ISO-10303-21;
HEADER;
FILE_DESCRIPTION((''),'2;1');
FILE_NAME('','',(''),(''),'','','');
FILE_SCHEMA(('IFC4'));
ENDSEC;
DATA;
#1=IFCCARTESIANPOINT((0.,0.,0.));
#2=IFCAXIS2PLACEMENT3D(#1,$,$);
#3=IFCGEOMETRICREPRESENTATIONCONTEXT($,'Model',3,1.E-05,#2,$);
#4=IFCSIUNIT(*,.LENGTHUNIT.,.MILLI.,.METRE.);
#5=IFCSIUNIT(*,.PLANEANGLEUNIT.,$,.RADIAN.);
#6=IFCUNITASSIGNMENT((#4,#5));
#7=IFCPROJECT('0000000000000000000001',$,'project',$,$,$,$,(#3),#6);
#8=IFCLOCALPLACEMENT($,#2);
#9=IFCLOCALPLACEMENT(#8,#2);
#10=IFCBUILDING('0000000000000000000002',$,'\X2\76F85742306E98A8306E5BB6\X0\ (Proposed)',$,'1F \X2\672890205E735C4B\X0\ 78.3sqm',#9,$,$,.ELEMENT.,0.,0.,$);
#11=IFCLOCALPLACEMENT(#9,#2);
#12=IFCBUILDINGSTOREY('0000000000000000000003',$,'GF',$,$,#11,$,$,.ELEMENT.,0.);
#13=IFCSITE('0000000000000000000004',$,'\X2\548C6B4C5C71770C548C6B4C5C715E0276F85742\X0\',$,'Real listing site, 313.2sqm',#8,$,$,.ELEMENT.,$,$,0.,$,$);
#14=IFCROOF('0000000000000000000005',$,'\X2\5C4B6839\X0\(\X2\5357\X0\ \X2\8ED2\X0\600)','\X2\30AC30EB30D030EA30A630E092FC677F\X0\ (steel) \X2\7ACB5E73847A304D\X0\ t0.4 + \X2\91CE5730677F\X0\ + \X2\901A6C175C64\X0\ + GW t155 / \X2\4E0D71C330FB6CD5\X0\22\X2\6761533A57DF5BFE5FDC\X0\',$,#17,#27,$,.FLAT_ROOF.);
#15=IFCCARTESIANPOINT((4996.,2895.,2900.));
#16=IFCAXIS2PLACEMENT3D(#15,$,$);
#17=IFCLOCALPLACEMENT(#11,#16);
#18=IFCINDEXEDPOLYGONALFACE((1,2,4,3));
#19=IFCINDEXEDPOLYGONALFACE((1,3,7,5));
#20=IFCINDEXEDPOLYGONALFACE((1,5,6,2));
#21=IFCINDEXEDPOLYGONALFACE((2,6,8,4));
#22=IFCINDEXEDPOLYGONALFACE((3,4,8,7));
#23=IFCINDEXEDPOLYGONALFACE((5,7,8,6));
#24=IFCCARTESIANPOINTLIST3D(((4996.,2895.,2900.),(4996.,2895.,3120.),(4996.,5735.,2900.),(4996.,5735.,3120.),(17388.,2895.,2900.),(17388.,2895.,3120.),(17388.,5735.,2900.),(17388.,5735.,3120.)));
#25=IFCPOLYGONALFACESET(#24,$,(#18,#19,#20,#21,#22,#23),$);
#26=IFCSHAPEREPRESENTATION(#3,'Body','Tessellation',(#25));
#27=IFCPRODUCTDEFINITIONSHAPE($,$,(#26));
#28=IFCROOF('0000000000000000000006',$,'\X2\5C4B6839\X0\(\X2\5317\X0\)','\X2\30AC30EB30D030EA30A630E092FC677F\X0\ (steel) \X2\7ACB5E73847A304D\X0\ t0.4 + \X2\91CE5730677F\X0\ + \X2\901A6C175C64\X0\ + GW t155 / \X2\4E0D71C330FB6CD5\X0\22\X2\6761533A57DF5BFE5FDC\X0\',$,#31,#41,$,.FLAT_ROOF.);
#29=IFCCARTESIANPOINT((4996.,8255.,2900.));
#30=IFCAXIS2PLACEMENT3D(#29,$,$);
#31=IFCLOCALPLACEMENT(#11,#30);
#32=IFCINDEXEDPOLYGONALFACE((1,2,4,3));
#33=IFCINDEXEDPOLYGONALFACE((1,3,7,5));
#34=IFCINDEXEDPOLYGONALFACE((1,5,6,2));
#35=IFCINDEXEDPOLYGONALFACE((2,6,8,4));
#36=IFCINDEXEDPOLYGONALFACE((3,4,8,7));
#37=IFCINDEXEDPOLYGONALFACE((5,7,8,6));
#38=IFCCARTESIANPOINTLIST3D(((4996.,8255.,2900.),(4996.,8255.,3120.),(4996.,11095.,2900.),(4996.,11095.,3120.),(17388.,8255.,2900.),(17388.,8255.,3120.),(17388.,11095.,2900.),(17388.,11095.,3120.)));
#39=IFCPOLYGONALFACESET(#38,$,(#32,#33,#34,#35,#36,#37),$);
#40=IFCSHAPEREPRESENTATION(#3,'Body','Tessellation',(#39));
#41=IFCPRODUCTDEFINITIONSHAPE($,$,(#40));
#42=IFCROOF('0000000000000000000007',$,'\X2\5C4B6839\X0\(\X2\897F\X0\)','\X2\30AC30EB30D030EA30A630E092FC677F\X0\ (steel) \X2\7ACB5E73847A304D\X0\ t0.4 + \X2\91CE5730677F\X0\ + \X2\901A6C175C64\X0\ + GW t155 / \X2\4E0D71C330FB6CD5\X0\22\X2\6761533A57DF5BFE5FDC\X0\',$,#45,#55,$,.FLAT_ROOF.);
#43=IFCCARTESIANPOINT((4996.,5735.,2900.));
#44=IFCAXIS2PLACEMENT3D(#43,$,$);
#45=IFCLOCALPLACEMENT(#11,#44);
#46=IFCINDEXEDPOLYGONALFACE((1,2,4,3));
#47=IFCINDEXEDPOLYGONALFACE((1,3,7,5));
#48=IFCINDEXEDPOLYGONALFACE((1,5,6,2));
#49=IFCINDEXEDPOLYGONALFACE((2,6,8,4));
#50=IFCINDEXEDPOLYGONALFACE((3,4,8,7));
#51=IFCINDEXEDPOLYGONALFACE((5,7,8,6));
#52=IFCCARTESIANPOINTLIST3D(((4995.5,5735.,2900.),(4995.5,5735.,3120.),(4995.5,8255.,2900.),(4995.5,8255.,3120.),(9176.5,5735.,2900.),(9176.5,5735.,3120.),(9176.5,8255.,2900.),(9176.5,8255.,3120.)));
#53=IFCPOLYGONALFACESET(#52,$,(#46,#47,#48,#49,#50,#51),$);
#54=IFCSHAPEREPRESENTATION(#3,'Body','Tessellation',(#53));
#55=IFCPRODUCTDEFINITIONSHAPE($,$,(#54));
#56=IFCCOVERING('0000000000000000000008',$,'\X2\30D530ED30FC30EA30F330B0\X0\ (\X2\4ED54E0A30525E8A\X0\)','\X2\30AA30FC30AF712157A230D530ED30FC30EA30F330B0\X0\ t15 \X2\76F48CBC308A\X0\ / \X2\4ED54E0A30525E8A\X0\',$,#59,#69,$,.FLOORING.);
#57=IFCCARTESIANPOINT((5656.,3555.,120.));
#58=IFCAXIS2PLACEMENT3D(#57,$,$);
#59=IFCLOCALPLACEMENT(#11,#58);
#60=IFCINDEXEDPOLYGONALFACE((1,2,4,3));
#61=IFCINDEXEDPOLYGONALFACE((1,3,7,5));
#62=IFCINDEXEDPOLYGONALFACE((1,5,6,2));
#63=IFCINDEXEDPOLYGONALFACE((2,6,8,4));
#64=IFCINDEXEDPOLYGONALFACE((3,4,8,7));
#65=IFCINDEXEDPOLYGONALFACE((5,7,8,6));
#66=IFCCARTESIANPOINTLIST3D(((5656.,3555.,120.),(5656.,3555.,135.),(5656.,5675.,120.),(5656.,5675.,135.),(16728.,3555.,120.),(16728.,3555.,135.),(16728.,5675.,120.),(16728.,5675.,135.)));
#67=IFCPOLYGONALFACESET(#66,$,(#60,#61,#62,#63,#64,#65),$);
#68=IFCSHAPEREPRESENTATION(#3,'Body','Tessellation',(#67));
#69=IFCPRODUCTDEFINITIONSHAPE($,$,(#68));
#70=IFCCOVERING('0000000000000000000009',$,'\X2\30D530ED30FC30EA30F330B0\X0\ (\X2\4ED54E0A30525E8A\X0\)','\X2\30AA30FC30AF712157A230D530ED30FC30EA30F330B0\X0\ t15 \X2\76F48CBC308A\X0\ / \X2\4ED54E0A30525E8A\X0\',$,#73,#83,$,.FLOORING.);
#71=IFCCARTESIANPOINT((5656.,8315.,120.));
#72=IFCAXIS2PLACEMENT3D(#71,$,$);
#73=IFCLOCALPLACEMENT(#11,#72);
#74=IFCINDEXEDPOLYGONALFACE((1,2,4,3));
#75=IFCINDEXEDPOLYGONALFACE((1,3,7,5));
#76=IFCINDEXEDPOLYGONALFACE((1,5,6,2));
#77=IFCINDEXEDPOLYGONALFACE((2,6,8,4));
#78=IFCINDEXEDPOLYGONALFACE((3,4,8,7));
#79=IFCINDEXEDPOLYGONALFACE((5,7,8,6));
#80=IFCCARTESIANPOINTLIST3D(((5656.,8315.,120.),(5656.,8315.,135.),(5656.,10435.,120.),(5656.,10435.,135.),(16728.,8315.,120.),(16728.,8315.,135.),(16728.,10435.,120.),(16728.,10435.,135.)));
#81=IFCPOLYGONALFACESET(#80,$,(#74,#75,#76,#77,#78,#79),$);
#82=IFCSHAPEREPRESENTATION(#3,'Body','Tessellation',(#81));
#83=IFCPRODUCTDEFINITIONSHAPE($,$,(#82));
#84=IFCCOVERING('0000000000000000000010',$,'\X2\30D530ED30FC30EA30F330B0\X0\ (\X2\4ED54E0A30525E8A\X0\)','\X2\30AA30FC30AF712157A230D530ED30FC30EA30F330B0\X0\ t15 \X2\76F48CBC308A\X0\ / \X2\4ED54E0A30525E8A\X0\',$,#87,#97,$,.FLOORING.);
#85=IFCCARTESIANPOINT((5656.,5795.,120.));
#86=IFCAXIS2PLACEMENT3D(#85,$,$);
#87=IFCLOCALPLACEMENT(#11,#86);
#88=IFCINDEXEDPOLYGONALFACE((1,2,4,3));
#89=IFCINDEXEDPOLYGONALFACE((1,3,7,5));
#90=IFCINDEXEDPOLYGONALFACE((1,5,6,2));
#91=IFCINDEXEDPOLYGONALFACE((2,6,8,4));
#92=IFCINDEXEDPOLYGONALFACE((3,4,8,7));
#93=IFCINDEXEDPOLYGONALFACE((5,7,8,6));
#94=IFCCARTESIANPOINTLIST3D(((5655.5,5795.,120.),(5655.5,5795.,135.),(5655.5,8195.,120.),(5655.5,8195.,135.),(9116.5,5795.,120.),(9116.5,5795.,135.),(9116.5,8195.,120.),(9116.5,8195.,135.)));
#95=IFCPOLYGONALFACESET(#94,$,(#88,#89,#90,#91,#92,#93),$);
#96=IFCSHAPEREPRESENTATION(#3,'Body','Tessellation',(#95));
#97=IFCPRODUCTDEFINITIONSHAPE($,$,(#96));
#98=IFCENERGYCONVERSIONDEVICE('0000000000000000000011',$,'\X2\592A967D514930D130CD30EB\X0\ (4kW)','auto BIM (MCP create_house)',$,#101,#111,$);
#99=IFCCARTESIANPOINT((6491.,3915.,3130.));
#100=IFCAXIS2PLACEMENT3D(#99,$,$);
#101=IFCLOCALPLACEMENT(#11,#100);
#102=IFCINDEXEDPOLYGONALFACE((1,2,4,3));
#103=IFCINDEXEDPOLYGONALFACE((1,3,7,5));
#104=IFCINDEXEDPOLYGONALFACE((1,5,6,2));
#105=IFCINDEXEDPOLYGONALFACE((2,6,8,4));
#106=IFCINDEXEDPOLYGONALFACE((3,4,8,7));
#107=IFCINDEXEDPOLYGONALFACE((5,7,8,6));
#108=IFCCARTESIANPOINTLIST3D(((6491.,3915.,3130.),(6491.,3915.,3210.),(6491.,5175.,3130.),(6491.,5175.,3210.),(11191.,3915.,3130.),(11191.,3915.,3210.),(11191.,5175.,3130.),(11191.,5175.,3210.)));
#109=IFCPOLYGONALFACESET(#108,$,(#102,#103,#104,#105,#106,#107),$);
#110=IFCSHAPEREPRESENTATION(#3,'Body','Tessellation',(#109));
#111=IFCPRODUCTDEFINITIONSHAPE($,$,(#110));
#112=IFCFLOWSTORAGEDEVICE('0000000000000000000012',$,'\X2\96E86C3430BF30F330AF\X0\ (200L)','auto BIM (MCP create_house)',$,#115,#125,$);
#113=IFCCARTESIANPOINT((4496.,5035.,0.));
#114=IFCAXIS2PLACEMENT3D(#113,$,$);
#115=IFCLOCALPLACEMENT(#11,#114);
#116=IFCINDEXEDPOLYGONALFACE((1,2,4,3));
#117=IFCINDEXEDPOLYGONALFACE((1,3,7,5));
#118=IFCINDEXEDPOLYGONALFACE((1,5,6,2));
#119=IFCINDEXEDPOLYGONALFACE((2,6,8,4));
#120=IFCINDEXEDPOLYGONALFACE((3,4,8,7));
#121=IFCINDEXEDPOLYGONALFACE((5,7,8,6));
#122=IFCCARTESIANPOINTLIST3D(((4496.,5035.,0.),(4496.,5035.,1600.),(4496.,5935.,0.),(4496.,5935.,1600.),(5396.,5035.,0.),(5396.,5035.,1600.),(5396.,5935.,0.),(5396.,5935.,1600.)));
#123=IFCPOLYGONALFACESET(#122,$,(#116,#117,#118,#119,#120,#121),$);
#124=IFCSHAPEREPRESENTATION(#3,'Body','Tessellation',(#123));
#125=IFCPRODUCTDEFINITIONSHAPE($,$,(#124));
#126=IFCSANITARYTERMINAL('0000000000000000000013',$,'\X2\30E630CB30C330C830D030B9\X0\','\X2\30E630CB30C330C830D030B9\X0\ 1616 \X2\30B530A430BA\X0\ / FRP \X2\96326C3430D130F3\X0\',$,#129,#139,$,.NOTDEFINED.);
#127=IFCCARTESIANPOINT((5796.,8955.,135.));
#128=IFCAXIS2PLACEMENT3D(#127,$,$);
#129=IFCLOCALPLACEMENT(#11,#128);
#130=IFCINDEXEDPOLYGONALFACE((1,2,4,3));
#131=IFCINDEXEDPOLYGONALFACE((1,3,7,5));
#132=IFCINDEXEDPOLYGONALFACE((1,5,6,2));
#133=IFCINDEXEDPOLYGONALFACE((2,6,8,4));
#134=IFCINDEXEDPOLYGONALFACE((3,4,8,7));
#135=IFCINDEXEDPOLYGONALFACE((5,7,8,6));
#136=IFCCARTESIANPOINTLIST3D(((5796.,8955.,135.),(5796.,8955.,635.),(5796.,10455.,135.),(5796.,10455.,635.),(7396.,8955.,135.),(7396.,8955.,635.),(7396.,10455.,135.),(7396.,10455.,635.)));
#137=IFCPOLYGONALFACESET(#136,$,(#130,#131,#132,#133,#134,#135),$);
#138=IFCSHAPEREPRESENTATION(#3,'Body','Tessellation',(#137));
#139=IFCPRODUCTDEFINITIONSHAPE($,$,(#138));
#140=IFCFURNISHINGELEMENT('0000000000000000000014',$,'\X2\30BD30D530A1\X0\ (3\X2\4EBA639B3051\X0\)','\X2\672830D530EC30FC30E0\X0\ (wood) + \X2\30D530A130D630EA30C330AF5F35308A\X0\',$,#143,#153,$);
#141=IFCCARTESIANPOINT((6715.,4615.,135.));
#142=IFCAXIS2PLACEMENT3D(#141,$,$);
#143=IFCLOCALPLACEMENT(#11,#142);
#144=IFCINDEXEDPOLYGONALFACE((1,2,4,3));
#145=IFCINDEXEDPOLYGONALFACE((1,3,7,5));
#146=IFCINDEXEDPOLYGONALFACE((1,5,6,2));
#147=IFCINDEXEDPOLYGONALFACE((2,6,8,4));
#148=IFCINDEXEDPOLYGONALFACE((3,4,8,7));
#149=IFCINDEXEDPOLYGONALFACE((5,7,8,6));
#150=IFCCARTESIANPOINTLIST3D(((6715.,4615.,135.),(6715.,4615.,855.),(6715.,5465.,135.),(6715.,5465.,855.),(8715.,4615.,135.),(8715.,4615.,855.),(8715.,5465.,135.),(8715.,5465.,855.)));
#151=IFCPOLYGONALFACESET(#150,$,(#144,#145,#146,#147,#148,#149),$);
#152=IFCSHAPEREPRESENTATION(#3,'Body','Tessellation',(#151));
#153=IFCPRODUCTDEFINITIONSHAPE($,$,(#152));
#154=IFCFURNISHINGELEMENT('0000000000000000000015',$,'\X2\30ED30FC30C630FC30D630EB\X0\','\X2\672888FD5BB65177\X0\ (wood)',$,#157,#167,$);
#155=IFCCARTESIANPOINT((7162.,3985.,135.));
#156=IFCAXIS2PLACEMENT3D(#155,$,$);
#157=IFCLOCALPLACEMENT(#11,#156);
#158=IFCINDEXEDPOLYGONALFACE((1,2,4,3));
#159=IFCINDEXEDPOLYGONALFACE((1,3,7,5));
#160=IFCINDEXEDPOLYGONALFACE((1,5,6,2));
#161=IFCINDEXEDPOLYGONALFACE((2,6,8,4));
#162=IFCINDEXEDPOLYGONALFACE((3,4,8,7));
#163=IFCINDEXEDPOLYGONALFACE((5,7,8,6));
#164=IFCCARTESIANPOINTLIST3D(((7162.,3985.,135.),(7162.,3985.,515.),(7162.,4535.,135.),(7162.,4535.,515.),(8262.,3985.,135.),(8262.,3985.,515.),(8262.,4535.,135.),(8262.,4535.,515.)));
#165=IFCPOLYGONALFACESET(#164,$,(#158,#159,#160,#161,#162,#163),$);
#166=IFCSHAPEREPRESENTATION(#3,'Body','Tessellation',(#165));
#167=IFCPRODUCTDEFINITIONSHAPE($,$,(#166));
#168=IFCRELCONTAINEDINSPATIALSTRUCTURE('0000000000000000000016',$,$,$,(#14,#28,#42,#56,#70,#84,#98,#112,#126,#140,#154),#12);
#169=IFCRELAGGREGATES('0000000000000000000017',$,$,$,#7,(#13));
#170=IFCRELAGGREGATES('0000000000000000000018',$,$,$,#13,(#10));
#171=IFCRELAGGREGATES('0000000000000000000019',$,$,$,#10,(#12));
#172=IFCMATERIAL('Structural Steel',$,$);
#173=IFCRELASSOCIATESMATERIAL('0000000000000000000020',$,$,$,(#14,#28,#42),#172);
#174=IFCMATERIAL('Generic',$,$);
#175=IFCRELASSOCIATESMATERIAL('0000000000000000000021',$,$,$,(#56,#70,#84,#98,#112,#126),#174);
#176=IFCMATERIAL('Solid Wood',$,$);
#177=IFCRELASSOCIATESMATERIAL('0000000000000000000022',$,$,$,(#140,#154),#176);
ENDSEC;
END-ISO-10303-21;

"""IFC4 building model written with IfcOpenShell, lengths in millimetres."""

from ifc_helpers import new_model, si_unit, frame, frame_2d, origin, place, context, project, spatial, rectangle, extrude, material, element, save


model = new_model("IFC4")

# Units and contexts
model_context = context("Model", 3, precision=1e-05, world=origin())
ifc_project = project(units=[si_unit("LENGTHUNIT", "METRE", prefix="MILLI"), si_unit("PLANEANGLEUNIT", "RADIAN")], contexts=[model_context])

# Site, building, storey
site_placement = place(None, origin())
site = spatial("IfcSite", under=ifc_project, at=site_placement, Name="和歌山県和歌山市相坂", ObjectType="Real listing site, 313.2sqm", CompositionType="ELEMENT", RefElevation=0.0)
building_placement = place(site_placement, origin())
building = spatial("IfcBuilding", under=site, at=building_placement, Name="相坂の風の家 (Proposed)", ObjectType="1F 木造平屋 78.3sqm", CompositionType="ELEMENT", ElevationOfRefHeight=0.0, ElevationOfTerrain=0.0)
storey_placement = place(building_placement, origin())
storey = spatial("IfcBuildingStorey", under=building, at=storey_placement, Name="GF", CompositionType="ELEMENT", Elevation=0.0)

# Shared definitions
ifc_material_1 = material(Name="Solid Wood")

# Roofs
ifc_material_2 = material(Name="Structural Steel")
roof_1_placement = place(storey_placement, frame((4996.0, 2895.0, 2900.0)))
element("IfcRoof", 1, at=roof_1_placement, inside=storey, material=ifc_material_2, Name="屋根(南 軒600)", Description="ガルバリウム鋼板 (steel) 立平葺き t0.4 + 野地板 + 通気層 + GW t155 / 不燃・法22条区域対応", PredefinedType="FLAT_ROOF", context=model_context, shape_type="SweptSolid", body=[
    extrude(rectangle(XDim=12392.0, YDim=2840.0, at=frame_2d((6196.0, 1420.0))), frame((4996.0, 2895.0, 2900.0)), (0.0, 0.0, 1.0), 220.0),
])
roof_2_placement = place(storey_placement, frame((4996.0, 8255.0, 2900.0)))
element("IfcRoof", 2, at=roof_2_placement, inside=storey, material=ifc_material_2, Name="屋根(北)", Description="ガルバリウム鋼板 (steel) 立平葺き t0.4 + 野地板 + 通気層 + GW t155 / 不燃・法22条区域対応", PredefinedType="FLAT_ROOF", context=model_context, shape_type="SweptSolid", body=[
    extrude(rectangle(XDim=12392.0, YDim=2840.0, at=frame_2d((6196.0, 1420.0))), frame((4996.0, 8255.0, 2900.0)), (0.0, 0.0, 1.0), 220.0),
])
roof_3_placement = place(storey_placement, frame((4996.0, 5735.0, 2900.0)))
element("IfcRoof", 3, at=roof_3_placement, inside=storey, material=ifc_material_2, Name="屋根(西)", Description="ガルバリウム鋼板 (steel) 立平葺き t0.4 + 野地板 + 通気層 + GW t155 / 不燃・法22条区域対応", PredefinedType="FLAT_ROOF", context=model_context, shape_type="SweptSolid", body=[
    extrude(rectangle(XDim=4181.0, YDim=2520.0, at=frame_2d((2090.0, 1260.0))), frame((4996.0, 5735.0, 2900.0)), (0.0, 0.0, 1.0), 220.0),
])

# Coverings
ifc_material_3 = material(Name="Generic")
covering_1_placement = place(storey_placement, frame((5656.0, 3555.0, 120.0)))
element("IfcCovering", 4, at=covering_1_placement, inside=storey, material=ifc_material_3, Name="フローリング (仕上げ床)", Description="オーク無垢フローリング t15 直貼り / 仕上げ床", PredefinedType="FLOORING", context=model_context, shape_type="SweptSolid", body=[
    extrude(rectangle(XDim=11072.0, YDim=2120.0, at=frame_2d((5536.0, 1060.0))), frame((5656.0, 3555.0, 120.0)), (0.0, 0.0, 1.0), 15.0),
])
covering_2_placement = place(storey_placement, frame((5656.0, 8315.0, 120.0)))
element("IfcCovering", 5, at=covering_2_placement, inside=storey, material=ifc_material_3, Name="フローリング (仕上げ床)", Description="オーク無垢フローリング t15 直貼り / 仕上げ床", PredefinedType="FLOORING", context=model_context, shape_type="SweptSolid", body=[
    extrude(rectangle(XDim=11072.0, YDim=2120.0, at=frame_2d((5536.0, 1060.0))), frame((5656.0, 8315.0, 120.0)), (0.0, 0.0, 1.0), 15.0),
])
covering_3_placement = place(storey_placement, frame((5656.0, 5795.0, 120.0)))
element("IfcCovering", 6, at=covering_3_placement, inside=storey, material=ifc_material_3, Name="フローリング (仕上げ床)", Description="オーク無垢フローリング t15 直貼り / 仕上げ床", PredefinedType="FLOORING", context=model_context, shape_type="SweptSolid", body=[
    extrude(rectangle(XDim=3461.0, YDim=2400.0, at=frame_2d((1730.0, 1200.0))), frame((5656.0, 5795.0, 120.0)), (0.0, 0.0, 1.0), 15.0),
])

# Energy conversion device
energy_conversion_device_placement = place(storey_placement, frame((6491.0, 3915.0, 3130.0)))
element("IfcEnergyConversionDevice", 7, at=energy_conversion_device_placement, inside=storey, material=ifc_material_3, Name="太陽光パネル (4kW)", Description="auto BIM (MCP create_house)", context=model_context, shape_type="SweptSolid", body=[
    extrude(rectangle(XDim=4700.0, YDim=1260.0, at=frame_2d((2350.0, 630.0))), frame((6491.0, 3915.0, 3130.0)), (0.0, 0.0, 1.0), 80.0),
])

# Flow storage device
flow_storage_device_placement = place(storey_placement, frame((4496.0, 5035.0, 0.0)))
element("IfcFlowStorageDevice", 8, at=flow_storage_device_placement, inside=storey, material=ifc_material_3, Name="雨水タンク (200L)", Description="auto BIM (MCP create_house)", context=model_context, shape_type="SweptSolid", body=[
    extrude(rectangle(XDim=900.0, YDim=900.0, at=frame_2d((450.0, 450.0))), frame((4496.0, 5035.0, 0.0)), (0.0, 0.0, 1.0), 1600.0),
])

# Sanitary terminal
sanitary_terminal_placement = place(storey_placement, frame((5796.0, 8955.0, 135.0)))
element("IfcSanitaryTerminal", 9, at=sanitary_terminal_placement, inside=storey, material=ifc_material_3, Name="ユニットバス", Description="ユニットバス 1616 サイズ / FRP 防水パン", PredefinedType="NOTDEFINED", context=model_context, shape_type="SweptSolid", body=[
    extrude(rectangle(XDim=1600.0, YDim=1500.0, at=frame_2d((800.0, 750.0))), frame((5796.0, 8955.0, 135.0)), (0.0, 0.0, 1.0), 500.0),
])

# Furnishing elements
furnishing_1_placement = place(storey_placement, frame((6715.0, 4615.0, 135.0)))
element("IfcFurnishingElement", 10, at=furnishing_1_placement, inside=storey, material=ifc_material_1, Name="ソファ (3人掛け)", Description="木フレーム (wood) + ファブリック張り", context=model_context, shape_type="SweptSolid", body=[
    extrude(rectangle(XDim=2000.0, YDim=850.0, at=frame_2d((1000.0, 425.0))), frame((6715.0, 4615.0, 135.0)), (0.0, 0.0, 1.0), 720.0),
])
furnishing_2_placement = place(storey_placement, frame((7162.0, 3985.0, 135.0)))
element("IfcFurnishingElement", 11, at=furnishing_2_placement, inside=storey, material=ifc_material_1, Name="ローテーブル", Description="木製家具 (wood)", context=model_context, shape_type="SweptSolid", body=[
    extrude(rectangle(XDim=1100.0, YDim=550.0, at=frame_2d((550.0, 275.0))), frame((7162.0, 3985.0, 135.0)), (0.0, 0.0, 1.0), 380.0),
])

save(model, "model.ifc")
